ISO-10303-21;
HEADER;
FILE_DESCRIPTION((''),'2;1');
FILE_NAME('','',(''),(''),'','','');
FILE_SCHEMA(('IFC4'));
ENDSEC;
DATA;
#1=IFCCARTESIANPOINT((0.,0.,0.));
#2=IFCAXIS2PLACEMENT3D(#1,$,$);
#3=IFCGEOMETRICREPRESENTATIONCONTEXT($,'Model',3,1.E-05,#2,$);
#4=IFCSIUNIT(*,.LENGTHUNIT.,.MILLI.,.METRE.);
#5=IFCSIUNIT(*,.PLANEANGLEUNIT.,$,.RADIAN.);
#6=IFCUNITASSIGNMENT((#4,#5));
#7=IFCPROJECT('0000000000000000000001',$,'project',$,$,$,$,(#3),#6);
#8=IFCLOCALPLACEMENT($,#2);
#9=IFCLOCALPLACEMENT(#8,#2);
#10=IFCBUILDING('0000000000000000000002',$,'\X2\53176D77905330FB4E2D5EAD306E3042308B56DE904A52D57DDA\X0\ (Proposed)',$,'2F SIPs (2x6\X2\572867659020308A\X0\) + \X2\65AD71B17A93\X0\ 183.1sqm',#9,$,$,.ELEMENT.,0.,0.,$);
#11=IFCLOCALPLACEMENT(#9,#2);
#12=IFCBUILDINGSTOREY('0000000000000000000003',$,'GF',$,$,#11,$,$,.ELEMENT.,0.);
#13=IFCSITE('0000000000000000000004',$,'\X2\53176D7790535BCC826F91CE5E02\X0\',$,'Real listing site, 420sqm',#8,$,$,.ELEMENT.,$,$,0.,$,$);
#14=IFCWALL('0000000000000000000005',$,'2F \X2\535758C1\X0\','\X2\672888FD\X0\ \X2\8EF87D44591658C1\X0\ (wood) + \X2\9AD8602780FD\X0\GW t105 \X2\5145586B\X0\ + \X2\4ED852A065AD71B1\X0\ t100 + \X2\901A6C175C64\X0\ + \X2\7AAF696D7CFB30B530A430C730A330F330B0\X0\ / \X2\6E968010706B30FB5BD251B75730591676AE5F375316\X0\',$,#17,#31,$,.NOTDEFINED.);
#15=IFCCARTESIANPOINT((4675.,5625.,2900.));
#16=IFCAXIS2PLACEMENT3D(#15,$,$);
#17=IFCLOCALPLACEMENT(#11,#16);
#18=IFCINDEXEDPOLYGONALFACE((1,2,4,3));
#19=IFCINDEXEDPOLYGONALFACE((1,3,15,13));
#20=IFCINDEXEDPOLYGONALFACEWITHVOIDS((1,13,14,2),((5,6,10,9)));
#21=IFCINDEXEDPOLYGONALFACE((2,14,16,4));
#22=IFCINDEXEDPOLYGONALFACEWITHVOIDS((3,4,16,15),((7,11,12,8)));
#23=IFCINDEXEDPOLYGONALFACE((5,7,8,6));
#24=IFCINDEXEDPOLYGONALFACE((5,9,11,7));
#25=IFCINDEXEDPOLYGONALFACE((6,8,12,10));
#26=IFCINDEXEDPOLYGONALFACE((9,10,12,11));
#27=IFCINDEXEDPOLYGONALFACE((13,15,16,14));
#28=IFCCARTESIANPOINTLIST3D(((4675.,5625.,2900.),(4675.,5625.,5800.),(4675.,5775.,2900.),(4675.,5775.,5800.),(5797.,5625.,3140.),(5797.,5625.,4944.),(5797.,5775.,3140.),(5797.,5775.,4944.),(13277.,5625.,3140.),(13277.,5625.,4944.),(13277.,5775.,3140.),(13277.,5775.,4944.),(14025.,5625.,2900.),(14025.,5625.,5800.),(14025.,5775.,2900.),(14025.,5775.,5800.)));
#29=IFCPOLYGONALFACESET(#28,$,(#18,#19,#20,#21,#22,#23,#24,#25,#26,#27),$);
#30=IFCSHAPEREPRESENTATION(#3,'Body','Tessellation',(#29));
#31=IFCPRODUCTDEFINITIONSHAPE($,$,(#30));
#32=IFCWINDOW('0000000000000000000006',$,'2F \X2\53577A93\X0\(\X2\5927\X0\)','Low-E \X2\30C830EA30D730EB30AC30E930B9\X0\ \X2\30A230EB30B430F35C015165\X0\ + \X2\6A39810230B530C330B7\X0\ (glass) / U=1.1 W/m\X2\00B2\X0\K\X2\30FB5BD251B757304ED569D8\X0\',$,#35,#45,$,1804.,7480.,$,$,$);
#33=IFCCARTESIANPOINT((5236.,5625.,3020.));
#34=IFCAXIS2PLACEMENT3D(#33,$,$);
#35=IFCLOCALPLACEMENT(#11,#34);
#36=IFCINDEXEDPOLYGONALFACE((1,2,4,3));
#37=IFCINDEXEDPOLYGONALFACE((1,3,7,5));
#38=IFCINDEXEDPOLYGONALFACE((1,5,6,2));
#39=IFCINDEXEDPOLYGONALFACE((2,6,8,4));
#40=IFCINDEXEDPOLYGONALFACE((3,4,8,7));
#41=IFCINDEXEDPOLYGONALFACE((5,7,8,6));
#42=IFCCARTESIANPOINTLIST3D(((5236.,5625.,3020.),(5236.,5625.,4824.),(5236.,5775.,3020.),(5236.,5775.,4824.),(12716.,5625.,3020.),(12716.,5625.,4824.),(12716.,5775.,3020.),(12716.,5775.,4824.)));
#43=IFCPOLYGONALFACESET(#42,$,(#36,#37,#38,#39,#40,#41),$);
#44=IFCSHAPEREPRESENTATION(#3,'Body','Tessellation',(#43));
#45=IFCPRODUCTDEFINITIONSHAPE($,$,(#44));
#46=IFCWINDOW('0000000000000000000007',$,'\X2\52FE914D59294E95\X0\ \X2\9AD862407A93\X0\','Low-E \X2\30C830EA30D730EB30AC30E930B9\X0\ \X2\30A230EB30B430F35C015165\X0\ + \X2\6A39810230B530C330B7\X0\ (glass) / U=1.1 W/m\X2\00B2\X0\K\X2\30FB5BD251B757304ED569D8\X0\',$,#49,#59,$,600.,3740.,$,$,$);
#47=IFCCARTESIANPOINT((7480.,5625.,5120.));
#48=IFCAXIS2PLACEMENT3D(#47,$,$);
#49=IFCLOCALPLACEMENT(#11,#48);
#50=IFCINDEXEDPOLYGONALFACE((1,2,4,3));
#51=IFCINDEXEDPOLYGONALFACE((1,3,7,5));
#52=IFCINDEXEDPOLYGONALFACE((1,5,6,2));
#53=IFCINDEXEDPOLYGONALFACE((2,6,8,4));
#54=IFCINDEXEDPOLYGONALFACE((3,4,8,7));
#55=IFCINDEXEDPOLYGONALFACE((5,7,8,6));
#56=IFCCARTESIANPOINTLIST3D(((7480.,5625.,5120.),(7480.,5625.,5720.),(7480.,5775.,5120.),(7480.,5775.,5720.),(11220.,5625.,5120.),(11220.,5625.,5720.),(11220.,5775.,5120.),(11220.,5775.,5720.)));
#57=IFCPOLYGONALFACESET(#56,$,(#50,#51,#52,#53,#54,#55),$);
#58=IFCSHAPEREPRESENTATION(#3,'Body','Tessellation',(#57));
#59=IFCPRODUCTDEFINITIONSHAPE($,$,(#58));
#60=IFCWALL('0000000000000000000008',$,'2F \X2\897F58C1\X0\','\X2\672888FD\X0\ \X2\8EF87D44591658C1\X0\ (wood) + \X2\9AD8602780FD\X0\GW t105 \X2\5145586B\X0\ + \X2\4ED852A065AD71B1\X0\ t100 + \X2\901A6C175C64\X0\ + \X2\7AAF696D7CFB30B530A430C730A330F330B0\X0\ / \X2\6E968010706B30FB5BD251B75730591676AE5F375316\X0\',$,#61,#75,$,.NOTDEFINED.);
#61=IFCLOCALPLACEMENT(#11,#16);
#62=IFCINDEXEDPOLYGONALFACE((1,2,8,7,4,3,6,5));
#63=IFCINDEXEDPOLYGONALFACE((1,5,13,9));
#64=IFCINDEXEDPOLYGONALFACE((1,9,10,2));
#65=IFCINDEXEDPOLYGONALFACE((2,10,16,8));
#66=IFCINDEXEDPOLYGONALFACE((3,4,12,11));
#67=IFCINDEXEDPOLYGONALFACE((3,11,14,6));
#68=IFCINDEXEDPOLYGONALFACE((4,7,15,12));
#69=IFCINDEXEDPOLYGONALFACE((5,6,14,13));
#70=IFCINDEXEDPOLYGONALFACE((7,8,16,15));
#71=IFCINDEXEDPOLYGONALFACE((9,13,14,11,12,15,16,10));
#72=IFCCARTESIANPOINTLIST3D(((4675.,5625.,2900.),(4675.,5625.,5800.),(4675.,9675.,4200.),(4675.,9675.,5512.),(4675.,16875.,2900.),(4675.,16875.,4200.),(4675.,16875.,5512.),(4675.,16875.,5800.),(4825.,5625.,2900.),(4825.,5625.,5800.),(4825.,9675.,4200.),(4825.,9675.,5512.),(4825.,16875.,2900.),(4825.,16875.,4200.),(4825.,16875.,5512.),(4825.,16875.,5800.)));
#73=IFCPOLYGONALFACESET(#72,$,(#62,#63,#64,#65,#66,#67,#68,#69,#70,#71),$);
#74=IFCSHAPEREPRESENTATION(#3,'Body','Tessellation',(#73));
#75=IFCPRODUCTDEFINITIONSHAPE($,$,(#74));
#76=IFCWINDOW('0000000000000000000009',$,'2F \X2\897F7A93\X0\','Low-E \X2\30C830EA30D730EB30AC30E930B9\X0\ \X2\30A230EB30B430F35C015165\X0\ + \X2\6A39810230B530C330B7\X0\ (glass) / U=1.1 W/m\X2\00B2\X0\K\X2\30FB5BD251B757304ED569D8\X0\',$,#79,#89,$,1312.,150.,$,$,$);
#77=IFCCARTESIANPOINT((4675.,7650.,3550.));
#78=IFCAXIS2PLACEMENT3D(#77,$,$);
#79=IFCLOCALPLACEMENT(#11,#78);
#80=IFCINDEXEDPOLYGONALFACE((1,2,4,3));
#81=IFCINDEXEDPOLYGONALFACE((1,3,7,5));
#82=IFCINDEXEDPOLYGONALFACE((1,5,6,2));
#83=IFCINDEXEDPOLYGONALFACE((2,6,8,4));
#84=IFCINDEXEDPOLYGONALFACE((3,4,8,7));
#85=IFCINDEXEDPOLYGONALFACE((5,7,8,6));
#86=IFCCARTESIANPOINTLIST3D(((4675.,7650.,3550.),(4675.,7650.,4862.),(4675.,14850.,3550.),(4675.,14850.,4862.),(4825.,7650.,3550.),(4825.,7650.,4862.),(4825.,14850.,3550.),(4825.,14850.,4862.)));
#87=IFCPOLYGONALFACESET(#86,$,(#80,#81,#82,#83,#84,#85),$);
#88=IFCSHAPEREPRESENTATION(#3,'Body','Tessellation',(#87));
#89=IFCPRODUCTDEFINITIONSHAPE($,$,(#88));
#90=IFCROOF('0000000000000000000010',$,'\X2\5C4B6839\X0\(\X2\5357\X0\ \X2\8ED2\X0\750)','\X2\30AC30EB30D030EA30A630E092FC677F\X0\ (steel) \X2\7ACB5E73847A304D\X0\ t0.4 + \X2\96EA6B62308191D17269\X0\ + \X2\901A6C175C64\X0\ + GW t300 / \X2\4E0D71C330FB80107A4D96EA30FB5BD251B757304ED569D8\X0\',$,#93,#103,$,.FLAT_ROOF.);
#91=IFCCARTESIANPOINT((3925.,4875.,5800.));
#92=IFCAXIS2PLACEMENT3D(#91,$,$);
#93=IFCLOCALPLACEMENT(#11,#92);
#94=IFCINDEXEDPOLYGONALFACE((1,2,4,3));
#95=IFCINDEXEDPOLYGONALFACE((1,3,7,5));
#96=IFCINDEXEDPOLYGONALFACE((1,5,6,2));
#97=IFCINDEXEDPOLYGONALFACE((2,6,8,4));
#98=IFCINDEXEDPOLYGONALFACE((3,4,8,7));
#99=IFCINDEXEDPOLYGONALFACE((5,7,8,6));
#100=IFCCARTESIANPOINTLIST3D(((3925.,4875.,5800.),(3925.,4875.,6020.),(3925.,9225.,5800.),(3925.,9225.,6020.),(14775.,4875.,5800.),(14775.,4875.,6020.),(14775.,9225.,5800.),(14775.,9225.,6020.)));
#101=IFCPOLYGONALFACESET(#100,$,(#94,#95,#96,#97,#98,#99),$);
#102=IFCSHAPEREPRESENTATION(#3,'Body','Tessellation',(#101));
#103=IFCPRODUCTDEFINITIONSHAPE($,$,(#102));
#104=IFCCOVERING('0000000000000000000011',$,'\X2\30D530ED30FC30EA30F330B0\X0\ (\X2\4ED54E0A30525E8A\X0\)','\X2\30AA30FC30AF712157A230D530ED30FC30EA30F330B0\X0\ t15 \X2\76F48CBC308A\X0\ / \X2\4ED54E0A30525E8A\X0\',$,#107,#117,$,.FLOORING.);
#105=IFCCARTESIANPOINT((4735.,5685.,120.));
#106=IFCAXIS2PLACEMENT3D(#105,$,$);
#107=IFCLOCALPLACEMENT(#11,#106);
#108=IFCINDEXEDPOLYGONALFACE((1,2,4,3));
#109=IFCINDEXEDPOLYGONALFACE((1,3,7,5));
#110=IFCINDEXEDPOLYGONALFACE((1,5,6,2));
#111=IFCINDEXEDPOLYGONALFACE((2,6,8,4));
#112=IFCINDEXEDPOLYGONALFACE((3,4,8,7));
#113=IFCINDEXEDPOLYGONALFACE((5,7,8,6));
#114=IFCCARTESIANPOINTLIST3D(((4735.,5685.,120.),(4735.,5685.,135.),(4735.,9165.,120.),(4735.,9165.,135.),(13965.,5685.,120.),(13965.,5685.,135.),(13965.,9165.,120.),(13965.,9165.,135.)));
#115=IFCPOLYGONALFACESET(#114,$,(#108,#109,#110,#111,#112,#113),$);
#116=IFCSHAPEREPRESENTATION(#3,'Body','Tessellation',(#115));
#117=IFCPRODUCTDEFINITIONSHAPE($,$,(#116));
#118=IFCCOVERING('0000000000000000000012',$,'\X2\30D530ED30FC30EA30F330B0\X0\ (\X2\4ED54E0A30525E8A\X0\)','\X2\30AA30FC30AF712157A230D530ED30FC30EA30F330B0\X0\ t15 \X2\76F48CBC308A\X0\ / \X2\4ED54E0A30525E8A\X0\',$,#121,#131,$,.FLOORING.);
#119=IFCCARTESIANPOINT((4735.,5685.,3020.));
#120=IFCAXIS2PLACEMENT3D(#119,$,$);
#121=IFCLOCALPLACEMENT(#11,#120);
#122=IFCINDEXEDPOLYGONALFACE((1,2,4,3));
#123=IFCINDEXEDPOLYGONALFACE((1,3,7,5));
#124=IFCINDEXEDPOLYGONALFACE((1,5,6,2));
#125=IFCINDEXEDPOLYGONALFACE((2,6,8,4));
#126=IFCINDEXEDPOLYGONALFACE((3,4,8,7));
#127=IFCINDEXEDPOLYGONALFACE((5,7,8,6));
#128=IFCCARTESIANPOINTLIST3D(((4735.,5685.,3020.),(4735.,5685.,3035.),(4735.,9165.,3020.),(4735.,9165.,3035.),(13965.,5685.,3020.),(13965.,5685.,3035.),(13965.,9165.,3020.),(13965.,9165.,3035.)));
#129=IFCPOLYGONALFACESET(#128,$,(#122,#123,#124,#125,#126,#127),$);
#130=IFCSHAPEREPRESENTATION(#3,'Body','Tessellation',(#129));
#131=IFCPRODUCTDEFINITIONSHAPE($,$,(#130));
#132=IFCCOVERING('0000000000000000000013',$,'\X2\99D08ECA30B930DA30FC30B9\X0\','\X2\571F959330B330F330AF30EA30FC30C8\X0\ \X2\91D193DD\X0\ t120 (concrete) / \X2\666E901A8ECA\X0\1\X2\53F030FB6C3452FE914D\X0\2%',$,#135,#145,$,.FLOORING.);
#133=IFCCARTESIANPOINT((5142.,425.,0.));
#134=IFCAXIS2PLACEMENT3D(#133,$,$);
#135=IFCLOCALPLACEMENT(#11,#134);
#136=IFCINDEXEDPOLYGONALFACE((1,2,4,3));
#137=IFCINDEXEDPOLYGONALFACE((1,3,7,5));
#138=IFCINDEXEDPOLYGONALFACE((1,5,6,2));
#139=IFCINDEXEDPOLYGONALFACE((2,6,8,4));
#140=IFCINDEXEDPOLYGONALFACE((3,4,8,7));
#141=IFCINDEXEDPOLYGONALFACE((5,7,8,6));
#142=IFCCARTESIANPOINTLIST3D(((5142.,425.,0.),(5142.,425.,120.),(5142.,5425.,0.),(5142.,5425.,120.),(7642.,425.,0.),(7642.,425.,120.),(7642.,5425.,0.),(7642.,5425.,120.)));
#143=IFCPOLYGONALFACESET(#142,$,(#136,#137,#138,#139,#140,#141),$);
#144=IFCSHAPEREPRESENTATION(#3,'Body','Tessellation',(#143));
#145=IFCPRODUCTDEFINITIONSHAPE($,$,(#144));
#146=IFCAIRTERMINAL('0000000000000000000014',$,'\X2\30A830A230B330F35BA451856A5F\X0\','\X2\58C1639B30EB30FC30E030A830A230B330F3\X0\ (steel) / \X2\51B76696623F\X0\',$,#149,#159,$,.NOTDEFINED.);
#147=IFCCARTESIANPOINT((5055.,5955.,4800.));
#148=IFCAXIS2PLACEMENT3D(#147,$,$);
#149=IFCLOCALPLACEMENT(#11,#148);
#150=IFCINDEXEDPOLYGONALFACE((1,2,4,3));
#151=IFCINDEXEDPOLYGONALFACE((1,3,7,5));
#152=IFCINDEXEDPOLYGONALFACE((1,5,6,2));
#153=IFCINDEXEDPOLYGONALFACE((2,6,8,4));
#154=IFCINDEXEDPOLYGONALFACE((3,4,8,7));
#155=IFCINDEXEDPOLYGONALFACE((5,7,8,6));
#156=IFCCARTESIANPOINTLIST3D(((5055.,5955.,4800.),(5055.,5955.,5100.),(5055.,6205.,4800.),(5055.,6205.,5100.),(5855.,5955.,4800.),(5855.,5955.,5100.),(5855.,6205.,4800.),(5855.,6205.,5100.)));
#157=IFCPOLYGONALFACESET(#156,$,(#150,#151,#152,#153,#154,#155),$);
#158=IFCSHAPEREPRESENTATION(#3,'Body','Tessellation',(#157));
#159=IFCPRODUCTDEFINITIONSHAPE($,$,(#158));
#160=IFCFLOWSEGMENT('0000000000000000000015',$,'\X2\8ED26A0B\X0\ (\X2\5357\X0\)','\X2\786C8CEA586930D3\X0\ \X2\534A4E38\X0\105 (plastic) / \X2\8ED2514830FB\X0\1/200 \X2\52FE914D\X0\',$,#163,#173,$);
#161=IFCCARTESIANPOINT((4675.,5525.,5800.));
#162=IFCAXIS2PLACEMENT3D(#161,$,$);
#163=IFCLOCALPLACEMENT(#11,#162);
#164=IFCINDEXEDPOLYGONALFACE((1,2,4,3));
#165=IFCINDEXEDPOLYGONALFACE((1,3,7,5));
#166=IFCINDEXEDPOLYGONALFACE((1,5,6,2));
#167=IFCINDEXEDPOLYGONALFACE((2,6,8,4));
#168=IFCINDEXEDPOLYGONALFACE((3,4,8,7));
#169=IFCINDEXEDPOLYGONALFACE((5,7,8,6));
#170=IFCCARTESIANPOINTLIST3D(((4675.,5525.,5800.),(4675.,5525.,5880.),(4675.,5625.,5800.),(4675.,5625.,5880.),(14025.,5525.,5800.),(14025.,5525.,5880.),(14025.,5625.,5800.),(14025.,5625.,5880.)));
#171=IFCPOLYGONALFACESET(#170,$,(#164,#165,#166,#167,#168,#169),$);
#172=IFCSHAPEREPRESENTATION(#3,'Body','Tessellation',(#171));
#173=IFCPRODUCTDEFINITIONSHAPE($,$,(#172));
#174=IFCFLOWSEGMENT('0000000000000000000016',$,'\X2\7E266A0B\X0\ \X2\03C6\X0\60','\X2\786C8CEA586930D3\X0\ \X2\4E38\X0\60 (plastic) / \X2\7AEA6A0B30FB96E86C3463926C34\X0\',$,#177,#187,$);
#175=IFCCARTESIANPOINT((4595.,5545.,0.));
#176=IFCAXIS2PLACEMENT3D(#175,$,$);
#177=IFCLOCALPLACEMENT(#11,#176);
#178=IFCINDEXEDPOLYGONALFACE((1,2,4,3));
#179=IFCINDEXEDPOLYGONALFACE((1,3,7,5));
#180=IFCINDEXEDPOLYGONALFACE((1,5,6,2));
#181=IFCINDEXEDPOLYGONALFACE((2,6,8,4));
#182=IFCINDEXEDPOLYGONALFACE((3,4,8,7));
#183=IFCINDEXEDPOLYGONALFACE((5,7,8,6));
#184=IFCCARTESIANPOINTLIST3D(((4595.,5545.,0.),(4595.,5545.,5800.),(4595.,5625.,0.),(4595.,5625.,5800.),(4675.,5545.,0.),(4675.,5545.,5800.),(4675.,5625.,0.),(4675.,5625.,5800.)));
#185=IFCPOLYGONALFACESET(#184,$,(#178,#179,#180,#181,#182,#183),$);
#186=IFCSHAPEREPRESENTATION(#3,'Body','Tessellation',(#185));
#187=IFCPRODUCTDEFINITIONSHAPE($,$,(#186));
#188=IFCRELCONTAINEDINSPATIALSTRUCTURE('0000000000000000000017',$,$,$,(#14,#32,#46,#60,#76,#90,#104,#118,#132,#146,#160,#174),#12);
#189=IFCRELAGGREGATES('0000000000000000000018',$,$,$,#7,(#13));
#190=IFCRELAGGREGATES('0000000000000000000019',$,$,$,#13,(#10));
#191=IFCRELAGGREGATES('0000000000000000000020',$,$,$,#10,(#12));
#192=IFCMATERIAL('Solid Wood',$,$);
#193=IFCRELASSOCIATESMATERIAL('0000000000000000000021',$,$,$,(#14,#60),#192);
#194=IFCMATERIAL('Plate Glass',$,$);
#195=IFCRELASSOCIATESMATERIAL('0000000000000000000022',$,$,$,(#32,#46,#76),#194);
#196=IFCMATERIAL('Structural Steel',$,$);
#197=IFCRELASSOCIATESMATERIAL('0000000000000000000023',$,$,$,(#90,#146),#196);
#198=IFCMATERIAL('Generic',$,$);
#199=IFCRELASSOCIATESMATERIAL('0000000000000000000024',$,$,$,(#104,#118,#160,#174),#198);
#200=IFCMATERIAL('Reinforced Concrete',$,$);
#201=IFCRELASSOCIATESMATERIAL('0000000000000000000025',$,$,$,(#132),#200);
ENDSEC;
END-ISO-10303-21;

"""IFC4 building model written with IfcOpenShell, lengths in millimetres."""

from ifc_helpers import new_model, si_unit, frame, frame_2d, origin, place, context, project, spatial, rectangle, extrude, material, element, fill, save


model = new_model("IFC4")

# Units and contexts
model_context = context("Model", 3, precision=1e-05, world=origin())
ifc_project = project(units=[si_unit("LENGTHUNIT", "METRE", prefix="MILLI"), si_unit("PLANEANGLEUNIT", "RADIAN")], contexts=[model_context])

# Site, building, storey
site_placement = place(None, origin())
site = spatial("IfcSite", under=ifc_project, at=site_placement, Name="北海道富良野市", ObjectType="Real listing site, 420sqm", CompositionType="ELEMENT", RefElevation=0.0)
building_placement = place(site_placement, origin())
building = spatial("IfcBuilding", under=site, at=building_placement, Name="北海道・中庭のある回遊動線 (Proposed)", ObjectType="2F SIPs (2x6在来造り) + 断熱窓 183.1sqm", CompositionType="ELEMENT", ElevationOfRefHeight=0.0, ElevationOfTerrain=0.0)
storey_placement = place(building_placement, origin())
storey = spatial("IfcBuildingStorey", under=building, at=storey_placement, Name="GF", CompositionType="ELEMENT", Elevation=0.0)

# Shared definitions
ifc_material_1 = material(Name="Solid Wood")

# Shared definitions
ifc_material_2 = material(Name="Reinforced Concrete")

# Shared definitions
ifc_material_3 = material(Name="Plate Glass")

# Wall, openings, windows
wall_1_placement = place(storey_placement, frame((4675.0, 5625.0, 2900.0)))
wall_1 = element("IfcWall", 1, at=wall_1_placement, inside=storey, material=ifc_material_1, Name="2F 南壁", Description="木製 軸組外壁 (wood) + 高性能GW t105 充填 + 付加断熱 t100 + 通気層 + 窯業系サイディング / 準耐火・寒冷地外皮強化", PredefinedType="NOTDEFINED", context=model_context, shape_type="SweptSolid", body=[
    extrude(rectangle(XDim=9350.0, YDim=150.0, at=frame_2d((4675.0, 75.0))), frame((4675.0, 5625.0, 2900.0)), (0.0, 0.0, 1.0), 2900.0),
])
opening_1_placement = place(storey_placement, frame((5236.0, 5625.0, 3020.0)))
opening_1 = element("IfcOpeningElement", 2, at=opening_1_placement, cuts=wall_1, PredefinedType="NOTDEFINED", context=model_context, shape_type="SweptSolid", body=[
    extrude(rectangle(XDim=7480.0, YDim=150.0, at=frame_2d((3740.0, 75.0))), frame((5236.0, 5625.0, 3020.0)), (0.0, 0.0, 1.0), 1804.0),
])
opening_2_placement = place(storey_placement, frame((7480.0, 5625.0, 5120.0)))
opening_2 = element("IfcOpeningElement", 3, at=opening_2_placement, cuts=wall_1, PredefinedType="NOTDEFINED", context=model_context, shape_type="SweptSolid", body=[
    extrude(rectangle(XDim=3740.0, YDim=150.0, at=frame_2d((1870.0, 75.0))), frame((7480.0, 5625.0, 5120.0)), (0.0, 0.0, 1.0), 600.0),
])
window_1_placement = place(storey_placement, frame((5236.0, 5625.0, 3020.0)))
window_1 = element("IfcWindow", 4, at=window_1_placement, inside=storey, material=ifc_material_3, Name="2F 南窓(大)", Description="Low-E トリプルガラス アルゴン封入 + 樹脂サッシ (glass) / U=1.1 W/m²K・寒冷地仕様", OverallHeight=1804.0, OverallWidth=7480.0, context=model_context, shape_type="SweptSolid", body=[
    extrude(rectangle(XDim=7480.0, YDim=150.0, at=frame_2d((3740.0, 75.0))), frame((5236.0, 5625.0, 3020.0)), (0.0, 0.0, 1.0), 1804.0),
])
fill(opening_1, window_1)
window_2_placement = place(storey_placement, frame((7480.0, 5625.0, 5120.0)))
window_2 = element("IfcWindow", 5, at=window_2_placement, inside=storey, material=ifc_material_3, Name="勾配天井 高所窓", Description="Low-E トリプルガラス アルゴン封入 + 樹脂サッシ (glass) / U=1.1 W/m²K・寒冷地仕様", OverallHeight=600.0, OverallWidth=3740.0, context=model_context, shape_type="SweptSolid", body=[
    extrude(rectangle(XDim=3740.0, YDim=150.0, at=frame_2d((1870.0, 75.0))), frame((7480.0, 5625.0, 5120.0)), (0.0, 0.0, 1.0), 600.0),
])
fill(opening_2, window_2)

# Wall, opening, window
wall_2_placement = place(storey_placement, frame((4675.0, 5625.0, 2900.0)))
wall_2 = element("IfcWall", 6, at=wall_2_placement, inside=storey, material=ifc_material_1, Name="2F 西壁", Description="木製 軸組外壁 (wood) + 高性能GW t105 充填 + 付加断熱 t100 + 通気層 + 窯業系サイディング / 準耐火・寒冷地外皮強化", PredefinedType="NOTDEFINED", context=model_context, shape_type="SweptSolid", body=[
    extrude(rectangle(XDim=150.0, YDim=11250.0, at=frame_2d((75.0, 5625.0))), frame((4675.0, 5625.0, 2900.0)), (0.0, 0.0, 1.0), 2900.0),
])
opening_3_placement = place(storey_placement, frame((4675.0, 7650.0, 3550.0)))
opening_3 = element("IfcOpeningElement", 7, at=opening_3_placement, cuts=wall_2, PredefinedType="NOTDEFINED", context=model_context, shape_type="SweptSolid", body=[
    extrude(rectangle(XDim=150.0, YDim=7200.0, at=frame_2d((75.0, 3600.0))), frame((4675.0, 7650.0, 3550.0)), (0.0, 0.0, 1.0), 1312.0),
])
window_3_placement = place(storey_placement, frame((4675.0, 7650.0, 3550.0)))
window_3 = element("IfcWindow", 8, at=window_3_placement, inside=storey, material=ifc_material_3, Name="2F 西窓", Description="Low-E トリプルガラス アルゴン封入 + 樹脂サッシ (glass) / U=1.1 W/m²K・寒冷地仕様", OverallHeight=1312.0, OverallWidth=150.0, context=model_context, shape_type="SweptSolid", body=[
    extrude(rectangle(XDim=150.0, YDim=7200.0, at=frame_2d((75.0, 3600.0))), frame((4675.0, 7650.0, 3550.0)), (0.0, 0.0, 1.0), 1312.0),
])
fill(opening_3, window_3)

# Roof
ifc_material_4 = material(Name="Structural Steel")
for number, where, name in (
    (9, (3925.0, 4875.0, 5800.0), "屋根(南 軒750)"),
):
    element("IfcRoof", number, at=place(storey_placement, frame(where)), inside=storey, material=ifc_material_4, Name=name, Description="ガルバリウム鋼板 (steel) 立平葺き t0.4 + 雪止め金物 + 通気層 + GW t300 / 不燃・耐積雪・寒冷地仕様", PredefinedType="FLAT_ROOF", context=model_context, shape_type="SweptSolid", body=[
        extrude(rectangle(XDim=10850.0, YDim=4350.0, at=frame_2d((5425.0, 2175.0))), frame((3925.0, 4875.0, 5800.0)), (0.0, 0.0, 1.0), 220.0),
    ])

# Coverings
ifc_material_5 = material(Name="Generic")
covering_1_placement = place(storey_placement, frame((4735.0, 5685.0, 120.0)))
element("IfcCovering", 10, at=covering_1_placement, inside=storey, material=ifc_material_5, Name="フローリング (仕上げ床)", Description="オーク無垢フローリング t15 直貼り / 仕上げ床", PredefinedType="FLOORING", context=model_context, shape_type="SweptSolid", body=[
    extrude(rectangle(XDim=9230.0, YDim=3480.0, at=frame_2d((4615.0, 1740.0))), frame((4735.0, 5685.0, 120.0)), (0.0, 0.0, 1.0), 15.0),
])
covering_2_placement = place(storey_placement, frame((4735.0, 5685.0, 3020.0)))
element("IfcCovering", 11, at=covering_2_placement, inside=storey, material=ifc_material_5, Name="フローリング (仕上げ床)", Description="オーク無垢フローリング t15 直貼り / 仕上げ床", PredefinedType="FLOORING", context=model_context, shape_type="SweptSolid", body=[
    extrude(rectangle(XDim=9230.0, YDim=3480.0, at=frame_2d((4615.0, 1740.0))), frame((4735.0, 5685.0, 3020.0)), (0.0, 0.0, 1.0), 15.0),
])
covering_3_placement = place(storey_placement, frame((5142.0, 425.0, 0.0)))
element("IfcCovering", 12, at=covering_3_placement, inside=storey, material=ifc_material_2, Name="駐車スペース", Description="土間コンクリート 金鏝 t120 (concrete) / 普通車1台・水勾配2%", PredefinedType="FLOORING", context=model_context, shape_type="SweptSolid", body=[
    extrude(rectangle(XDim=2500.0, YDim=5000.0, at=frame_2d((1250.0, 2500.0))), frame((5142.0, 425.0, 0.0)), (0.0, 0.0, 1.0), 120.0),
])

# Air terminal
air_terminal_placement = place(storey_placement, frame((5055.0, 5955.0, 4800.0)))
element("IfcAirTerminal", 13, at=air_terminal_placement, inside=storey, material=ifc_material_4, Name="エアコン室内機", Description="壁掛ルームエアコン (steel) / 冷暖房", PredefinedType="NOTDEFINED", context=model_context, shape_type="SweptSolid", body=[
    extrude(rectangle(XDim=800.0, YDim=250.0, at=frame_2d((400.0, 125.0))), frame((5055.0, 5955.0, 4800.0)), (0.0, 0.0, 1.0), 300.0),
])

# Flow segments
flow_segment_1_placement = place(storey_placement, frame((4675.0, 5525.0, 5800.0)))
element("IfcFlowSegment", 14, at=flow_segment_1_placement, inside=storey, material=ifc_material_5, Name="軒樋 (南)", Description="硬質塩ビ 半丸105 (plastic) / 軒先・1/200 勾配", context=model_context, shape_type="SweptSolid", body=[
    extrude(rectangle(XDim=9350.0, YDim=100.0, at=frame_2d((4675.0, 50.0))), frame((4675.0, 5525.0, 5800.0)), (0.0, 0.0, 1.0), 80.0),
])
flow_segment_2_placement = place(storey_placement, frame((4595.0, 5545.0, 0.0)))
element("IfcFlowSegment", 15, at=flow_segment_2_placement, inside=storey, material=ifc_material_5, Name="縦樋 φ60", Description="硬質塩ビ 丸60 (plastic) / 竪樋・雨水排水", context=model_context, shape_type="SweptSolid", body=[
    extrude(rectangle(XDim=80.0, YDim=80.0, at=frame_2d((40.0, 40.0))), frame((4595.0, 5545.0, 0.0)), (0.0, 0.0, 1.0), 5800.0),
])

save(model, "model.ifc")
